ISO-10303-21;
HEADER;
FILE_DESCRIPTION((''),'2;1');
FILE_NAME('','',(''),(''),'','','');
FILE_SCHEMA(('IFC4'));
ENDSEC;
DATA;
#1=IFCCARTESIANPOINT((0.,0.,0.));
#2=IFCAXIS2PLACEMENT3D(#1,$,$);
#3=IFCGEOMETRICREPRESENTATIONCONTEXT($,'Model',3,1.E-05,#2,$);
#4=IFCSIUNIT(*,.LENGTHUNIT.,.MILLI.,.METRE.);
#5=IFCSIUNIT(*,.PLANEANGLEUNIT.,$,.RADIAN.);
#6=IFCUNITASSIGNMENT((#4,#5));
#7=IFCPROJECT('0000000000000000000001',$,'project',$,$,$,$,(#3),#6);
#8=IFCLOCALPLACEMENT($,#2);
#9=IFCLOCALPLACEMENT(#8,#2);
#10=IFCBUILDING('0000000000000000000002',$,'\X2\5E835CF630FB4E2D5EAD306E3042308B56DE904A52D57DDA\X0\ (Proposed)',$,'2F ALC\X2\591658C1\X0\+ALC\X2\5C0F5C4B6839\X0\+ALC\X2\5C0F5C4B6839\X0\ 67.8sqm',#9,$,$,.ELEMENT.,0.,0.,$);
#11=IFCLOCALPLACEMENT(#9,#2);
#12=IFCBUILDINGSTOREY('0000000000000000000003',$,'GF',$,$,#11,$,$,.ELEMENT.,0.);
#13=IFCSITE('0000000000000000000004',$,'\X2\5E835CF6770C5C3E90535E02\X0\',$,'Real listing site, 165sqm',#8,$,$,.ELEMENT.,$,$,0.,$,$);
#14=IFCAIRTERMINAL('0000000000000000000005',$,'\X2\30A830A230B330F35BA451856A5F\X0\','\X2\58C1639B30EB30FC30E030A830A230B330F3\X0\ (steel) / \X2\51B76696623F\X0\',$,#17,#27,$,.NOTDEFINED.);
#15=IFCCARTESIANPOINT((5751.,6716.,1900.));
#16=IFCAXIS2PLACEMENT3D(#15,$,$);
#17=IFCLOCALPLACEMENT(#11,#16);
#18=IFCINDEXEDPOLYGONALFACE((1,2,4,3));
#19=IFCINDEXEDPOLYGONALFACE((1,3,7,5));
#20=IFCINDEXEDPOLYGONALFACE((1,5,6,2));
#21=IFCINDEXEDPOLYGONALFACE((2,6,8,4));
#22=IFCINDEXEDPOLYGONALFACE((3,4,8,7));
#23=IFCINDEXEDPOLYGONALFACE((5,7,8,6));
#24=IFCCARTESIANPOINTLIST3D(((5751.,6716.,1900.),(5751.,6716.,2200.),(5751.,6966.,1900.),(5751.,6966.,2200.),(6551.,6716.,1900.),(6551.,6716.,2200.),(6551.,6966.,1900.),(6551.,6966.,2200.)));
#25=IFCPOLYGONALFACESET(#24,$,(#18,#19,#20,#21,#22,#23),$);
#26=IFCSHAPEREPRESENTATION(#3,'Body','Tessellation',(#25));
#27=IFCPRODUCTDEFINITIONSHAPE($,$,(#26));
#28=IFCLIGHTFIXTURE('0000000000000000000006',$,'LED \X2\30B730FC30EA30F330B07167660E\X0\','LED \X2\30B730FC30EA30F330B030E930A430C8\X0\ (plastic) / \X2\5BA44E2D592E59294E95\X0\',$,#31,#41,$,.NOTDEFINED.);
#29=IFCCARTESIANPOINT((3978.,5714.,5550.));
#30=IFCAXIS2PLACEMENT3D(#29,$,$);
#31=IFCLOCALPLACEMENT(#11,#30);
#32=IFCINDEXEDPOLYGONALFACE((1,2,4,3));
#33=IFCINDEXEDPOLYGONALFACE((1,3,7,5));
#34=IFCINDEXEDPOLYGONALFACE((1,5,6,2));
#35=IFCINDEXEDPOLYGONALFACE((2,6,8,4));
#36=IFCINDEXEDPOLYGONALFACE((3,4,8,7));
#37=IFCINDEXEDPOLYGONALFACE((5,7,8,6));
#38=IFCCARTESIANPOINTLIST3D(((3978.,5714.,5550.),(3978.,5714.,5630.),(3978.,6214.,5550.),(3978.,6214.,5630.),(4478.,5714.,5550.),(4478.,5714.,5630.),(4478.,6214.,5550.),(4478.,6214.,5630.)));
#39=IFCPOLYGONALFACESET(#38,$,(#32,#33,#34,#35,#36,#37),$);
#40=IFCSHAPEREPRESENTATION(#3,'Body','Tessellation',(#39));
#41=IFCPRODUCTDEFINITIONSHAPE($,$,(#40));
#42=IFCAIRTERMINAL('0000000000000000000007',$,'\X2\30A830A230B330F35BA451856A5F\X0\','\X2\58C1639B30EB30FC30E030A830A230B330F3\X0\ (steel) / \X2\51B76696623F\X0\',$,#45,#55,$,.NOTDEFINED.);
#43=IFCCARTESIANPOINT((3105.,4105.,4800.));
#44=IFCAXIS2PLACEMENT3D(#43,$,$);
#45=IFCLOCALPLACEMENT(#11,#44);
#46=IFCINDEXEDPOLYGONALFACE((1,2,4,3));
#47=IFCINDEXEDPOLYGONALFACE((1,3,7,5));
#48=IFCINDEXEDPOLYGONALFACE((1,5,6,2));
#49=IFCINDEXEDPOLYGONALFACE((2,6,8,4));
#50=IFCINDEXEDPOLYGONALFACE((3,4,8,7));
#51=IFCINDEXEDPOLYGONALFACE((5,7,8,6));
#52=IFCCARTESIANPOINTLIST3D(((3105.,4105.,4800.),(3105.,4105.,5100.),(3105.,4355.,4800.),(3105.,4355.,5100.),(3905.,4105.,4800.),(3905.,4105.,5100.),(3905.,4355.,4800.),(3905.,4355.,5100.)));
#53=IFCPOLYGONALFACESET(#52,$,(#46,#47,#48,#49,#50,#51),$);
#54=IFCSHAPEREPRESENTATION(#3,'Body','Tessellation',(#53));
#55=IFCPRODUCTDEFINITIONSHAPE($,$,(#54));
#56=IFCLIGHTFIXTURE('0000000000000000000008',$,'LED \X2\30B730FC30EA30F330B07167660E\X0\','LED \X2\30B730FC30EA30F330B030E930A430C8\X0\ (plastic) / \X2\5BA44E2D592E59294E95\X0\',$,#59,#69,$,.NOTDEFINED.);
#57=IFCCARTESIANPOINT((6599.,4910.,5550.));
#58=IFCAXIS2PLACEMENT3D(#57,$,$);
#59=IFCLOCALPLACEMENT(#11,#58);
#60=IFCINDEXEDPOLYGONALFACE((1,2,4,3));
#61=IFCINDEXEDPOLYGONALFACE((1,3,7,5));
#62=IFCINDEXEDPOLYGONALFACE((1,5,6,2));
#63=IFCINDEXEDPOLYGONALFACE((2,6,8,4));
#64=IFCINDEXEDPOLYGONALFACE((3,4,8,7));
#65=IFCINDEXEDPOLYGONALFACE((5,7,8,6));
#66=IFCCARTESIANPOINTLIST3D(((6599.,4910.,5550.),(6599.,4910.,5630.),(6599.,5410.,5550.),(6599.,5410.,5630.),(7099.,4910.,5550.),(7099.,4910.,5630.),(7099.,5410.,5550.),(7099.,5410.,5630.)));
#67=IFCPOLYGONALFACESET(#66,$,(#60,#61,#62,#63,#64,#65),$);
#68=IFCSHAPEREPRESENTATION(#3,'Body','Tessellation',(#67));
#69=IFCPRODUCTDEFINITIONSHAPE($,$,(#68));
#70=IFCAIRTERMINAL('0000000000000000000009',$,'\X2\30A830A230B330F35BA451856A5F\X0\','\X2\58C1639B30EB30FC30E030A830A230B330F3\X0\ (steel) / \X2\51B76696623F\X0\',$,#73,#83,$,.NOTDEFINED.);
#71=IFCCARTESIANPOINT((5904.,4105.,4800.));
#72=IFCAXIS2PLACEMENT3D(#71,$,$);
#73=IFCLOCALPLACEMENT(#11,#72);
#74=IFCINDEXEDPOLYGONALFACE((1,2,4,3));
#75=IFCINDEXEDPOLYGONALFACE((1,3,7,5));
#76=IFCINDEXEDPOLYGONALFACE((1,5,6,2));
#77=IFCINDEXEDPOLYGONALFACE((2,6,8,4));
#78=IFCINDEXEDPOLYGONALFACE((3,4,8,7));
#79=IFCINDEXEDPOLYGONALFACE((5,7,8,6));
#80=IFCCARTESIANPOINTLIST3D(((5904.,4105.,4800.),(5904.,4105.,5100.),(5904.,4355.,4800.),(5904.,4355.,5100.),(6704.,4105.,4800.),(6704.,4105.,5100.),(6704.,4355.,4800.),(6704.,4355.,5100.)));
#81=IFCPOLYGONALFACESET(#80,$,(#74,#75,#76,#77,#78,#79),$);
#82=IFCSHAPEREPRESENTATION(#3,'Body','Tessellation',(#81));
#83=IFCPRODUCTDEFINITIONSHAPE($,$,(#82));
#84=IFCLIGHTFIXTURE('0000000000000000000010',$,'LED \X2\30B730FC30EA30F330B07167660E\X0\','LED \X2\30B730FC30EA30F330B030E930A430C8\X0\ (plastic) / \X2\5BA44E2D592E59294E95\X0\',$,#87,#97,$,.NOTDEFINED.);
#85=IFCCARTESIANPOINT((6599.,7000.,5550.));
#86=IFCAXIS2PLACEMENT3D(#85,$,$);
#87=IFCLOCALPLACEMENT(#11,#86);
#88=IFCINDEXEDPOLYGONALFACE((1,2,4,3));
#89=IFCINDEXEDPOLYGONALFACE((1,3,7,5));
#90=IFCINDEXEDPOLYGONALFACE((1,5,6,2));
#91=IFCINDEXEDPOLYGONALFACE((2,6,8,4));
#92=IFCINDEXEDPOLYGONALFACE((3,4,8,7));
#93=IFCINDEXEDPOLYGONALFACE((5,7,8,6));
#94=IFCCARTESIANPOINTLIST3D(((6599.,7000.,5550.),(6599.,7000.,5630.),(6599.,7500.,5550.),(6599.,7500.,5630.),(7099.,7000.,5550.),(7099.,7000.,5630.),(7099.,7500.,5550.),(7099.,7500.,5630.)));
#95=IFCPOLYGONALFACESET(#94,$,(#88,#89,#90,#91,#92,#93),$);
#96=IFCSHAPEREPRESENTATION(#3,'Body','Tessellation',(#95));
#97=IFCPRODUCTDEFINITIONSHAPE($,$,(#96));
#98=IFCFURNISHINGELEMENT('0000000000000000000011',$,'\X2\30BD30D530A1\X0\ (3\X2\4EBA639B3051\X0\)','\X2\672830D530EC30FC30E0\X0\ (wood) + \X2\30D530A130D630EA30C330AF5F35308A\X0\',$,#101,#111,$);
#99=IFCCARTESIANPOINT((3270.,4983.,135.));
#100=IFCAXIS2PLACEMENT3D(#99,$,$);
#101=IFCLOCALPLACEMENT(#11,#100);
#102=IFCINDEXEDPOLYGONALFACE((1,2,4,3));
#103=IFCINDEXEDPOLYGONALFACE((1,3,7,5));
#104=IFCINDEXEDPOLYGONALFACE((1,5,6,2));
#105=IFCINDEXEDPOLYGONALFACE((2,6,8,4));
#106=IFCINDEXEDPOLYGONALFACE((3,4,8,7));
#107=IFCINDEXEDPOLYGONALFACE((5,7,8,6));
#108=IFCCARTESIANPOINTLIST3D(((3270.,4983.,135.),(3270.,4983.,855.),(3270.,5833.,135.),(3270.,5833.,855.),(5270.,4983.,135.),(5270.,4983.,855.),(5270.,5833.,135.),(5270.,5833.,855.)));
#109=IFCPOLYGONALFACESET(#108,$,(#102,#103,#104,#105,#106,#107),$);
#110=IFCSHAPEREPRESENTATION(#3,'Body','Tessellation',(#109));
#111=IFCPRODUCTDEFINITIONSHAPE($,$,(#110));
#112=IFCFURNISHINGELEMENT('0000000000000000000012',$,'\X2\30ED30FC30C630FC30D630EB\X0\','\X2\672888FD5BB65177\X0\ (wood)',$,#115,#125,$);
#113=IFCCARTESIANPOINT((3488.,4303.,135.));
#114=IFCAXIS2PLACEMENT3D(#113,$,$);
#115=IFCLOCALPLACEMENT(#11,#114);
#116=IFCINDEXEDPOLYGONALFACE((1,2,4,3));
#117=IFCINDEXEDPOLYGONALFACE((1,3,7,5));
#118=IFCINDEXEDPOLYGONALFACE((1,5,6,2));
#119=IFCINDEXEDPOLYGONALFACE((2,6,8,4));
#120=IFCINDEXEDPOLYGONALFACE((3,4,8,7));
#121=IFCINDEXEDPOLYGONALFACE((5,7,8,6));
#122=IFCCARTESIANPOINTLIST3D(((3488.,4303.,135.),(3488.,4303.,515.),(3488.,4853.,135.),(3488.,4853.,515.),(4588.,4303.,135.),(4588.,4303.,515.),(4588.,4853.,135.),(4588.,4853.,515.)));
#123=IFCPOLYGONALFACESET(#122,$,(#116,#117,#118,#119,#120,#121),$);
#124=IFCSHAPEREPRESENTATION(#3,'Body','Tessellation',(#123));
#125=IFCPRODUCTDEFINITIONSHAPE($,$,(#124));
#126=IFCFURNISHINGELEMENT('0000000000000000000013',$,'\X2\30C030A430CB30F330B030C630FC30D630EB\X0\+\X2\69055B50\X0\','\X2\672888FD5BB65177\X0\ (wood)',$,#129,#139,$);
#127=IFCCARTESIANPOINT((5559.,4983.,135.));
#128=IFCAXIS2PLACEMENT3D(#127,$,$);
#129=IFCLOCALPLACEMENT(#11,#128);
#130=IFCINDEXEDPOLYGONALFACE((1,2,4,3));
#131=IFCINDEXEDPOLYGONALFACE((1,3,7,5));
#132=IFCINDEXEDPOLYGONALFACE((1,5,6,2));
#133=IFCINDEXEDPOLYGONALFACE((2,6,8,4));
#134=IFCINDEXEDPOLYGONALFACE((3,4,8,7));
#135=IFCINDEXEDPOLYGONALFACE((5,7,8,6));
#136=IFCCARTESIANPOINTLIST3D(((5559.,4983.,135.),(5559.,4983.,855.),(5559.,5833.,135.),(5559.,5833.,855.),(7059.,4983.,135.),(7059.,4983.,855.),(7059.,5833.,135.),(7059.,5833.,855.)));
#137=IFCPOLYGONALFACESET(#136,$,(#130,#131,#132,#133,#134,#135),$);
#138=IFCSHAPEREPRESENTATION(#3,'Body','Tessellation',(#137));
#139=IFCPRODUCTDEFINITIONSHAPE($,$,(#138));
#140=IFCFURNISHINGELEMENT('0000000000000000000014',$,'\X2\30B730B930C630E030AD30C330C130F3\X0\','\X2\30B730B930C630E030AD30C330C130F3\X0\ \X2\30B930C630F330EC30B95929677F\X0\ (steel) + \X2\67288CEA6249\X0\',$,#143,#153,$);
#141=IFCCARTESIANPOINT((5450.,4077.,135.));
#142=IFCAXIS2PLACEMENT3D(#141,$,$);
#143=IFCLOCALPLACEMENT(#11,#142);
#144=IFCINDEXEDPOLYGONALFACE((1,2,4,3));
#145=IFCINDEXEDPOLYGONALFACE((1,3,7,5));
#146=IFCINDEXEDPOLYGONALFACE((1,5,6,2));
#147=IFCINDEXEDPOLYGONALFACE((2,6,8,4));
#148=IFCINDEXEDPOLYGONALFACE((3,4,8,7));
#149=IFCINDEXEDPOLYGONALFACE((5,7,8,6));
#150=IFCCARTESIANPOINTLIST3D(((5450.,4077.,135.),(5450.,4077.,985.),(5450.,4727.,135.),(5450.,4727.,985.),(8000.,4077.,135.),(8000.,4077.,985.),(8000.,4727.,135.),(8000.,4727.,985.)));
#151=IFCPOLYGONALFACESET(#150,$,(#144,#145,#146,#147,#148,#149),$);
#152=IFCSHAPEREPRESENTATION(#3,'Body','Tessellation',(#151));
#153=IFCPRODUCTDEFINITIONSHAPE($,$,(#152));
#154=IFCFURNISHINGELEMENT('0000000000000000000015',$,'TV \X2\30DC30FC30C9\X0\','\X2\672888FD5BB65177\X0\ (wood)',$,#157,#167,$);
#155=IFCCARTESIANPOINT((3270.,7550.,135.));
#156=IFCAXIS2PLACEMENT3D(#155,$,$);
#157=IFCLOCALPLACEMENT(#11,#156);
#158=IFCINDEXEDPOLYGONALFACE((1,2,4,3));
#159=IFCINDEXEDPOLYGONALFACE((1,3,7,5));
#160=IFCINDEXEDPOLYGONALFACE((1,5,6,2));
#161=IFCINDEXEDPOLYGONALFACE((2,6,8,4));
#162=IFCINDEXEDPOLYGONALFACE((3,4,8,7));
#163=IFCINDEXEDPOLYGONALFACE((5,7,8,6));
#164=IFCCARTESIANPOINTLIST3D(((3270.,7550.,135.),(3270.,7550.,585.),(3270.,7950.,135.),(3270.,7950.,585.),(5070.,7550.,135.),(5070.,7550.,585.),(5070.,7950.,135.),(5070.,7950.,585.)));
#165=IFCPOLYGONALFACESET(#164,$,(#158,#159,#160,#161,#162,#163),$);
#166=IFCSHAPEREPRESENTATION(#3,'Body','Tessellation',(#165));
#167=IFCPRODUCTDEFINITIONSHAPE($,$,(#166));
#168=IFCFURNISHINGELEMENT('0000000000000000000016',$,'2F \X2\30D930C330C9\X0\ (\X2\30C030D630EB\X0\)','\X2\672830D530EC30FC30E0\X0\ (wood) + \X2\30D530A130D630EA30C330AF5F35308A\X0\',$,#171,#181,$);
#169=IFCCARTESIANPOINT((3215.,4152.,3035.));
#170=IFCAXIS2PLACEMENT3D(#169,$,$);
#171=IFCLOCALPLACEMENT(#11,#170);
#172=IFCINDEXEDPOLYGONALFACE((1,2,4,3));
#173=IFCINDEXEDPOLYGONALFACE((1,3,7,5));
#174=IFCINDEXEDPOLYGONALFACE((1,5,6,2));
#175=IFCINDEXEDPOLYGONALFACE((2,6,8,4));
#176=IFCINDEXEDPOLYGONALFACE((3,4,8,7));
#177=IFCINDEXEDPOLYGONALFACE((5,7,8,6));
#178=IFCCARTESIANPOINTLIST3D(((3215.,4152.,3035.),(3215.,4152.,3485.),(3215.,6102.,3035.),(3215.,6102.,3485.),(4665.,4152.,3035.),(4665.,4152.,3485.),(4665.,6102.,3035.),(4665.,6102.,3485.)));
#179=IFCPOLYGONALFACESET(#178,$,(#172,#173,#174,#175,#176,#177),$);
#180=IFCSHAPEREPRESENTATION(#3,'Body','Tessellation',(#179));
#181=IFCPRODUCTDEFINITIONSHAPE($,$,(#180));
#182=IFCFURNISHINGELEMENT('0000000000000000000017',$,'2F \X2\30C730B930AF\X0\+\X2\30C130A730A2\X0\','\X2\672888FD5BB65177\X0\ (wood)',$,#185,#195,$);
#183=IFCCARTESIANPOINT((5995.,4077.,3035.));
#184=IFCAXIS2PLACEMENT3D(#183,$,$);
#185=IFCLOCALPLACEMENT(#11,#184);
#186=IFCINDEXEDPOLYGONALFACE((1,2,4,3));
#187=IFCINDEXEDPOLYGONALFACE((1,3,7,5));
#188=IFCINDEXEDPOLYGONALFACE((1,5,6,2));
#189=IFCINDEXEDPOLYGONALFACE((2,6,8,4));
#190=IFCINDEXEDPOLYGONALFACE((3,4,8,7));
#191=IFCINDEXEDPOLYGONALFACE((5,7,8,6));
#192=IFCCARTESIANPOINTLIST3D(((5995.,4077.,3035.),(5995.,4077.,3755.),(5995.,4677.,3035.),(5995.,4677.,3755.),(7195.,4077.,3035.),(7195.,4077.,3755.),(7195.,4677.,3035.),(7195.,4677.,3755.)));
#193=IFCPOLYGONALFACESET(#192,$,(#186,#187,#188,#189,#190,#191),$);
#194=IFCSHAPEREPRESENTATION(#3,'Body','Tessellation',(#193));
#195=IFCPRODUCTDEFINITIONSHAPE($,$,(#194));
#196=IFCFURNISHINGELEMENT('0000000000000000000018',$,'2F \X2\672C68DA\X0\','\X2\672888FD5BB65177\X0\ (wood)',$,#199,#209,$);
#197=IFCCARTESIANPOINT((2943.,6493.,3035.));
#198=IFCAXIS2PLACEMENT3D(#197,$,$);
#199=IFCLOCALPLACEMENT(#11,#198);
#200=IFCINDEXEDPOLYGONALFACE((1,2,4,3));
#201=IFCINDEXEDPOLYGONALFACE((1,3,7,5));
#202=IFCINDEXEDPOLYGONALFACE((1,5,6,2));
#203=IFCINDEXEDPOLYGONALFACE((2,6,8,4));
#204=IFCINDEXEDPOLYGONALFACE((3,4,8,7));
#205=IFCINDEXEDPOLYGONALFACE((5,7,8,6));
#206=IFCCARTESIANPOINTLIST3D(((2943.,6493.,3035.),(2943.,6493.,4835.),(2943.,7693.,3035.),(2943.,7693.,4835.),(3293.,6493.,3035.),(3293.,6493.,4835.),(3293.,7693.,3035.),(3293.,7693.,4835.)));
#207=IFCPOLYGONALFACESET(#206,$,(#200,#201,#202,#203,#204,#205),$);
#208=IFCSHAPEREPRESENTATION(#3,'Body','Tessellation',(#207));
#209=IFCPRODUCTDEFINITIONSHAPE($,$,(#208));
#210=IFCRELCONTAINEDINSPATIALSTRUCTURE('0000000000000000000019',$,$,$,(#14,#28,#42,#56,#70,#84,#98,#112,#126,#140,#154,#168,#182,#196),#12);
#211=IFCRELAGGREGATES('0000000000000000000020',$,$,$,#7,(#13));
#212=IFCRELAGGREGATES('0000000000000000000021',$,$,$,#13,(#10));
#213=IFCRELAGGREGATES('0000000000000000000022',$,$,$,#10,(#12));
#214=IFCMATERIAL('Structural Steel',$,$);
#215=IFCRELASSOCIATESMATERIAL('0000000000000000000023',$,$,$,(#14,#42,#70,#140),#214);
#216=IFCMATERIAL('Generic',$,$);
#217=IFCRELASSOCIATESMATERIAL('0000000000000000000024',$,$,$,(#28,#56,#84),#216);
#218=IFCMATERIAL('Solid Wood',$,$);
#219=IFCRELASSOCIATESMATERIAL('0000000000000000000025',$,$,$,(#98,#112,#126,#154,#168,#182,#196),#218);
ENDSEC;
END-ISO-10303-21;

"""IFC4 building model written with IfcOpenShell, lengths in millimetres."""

from ifc_helpers import new_model, si_unit, frame, frame_2d, origin, place, context, project, spatial, rectangle, extrude, material, element, save


model = new_model("IFC4")

# Units and contexts
model_context = context("Model", 3, precision=1e-05, world=origin())
ifc_project = project(units=[si_unit("LENGTHUNIT", "METRE", prefix="MILLI"), si_unit("PLANEANGLEUNIT", "RADIAN")], contexts=[model_context])

# Site, building, storey
site_placement = place(None, origin())
site = spatial("IfcSite", under=ifc_project, at=site_placement, Name="広島県尾道市", ObjectType="Real listing site, 165sqm", CompositionType="ELEMENT", RefElevation=0.0)
building_placement = place(site_placement, origin())
building = spatial("IfcBuilding", under=site, at=building_placement, Name="広島・中庭のある回遊動線 (Proposed)", ObjectType="2F ALC外壁+ALC小屋根+ALC小屋根 67.8sqm", CompositionType="ELEMENT", ElevationOfRefHeight=0.0, ElevationOfTerrain=0.0)
storey_placement = place(building_placement, origin())
storey = spatial("IfcBuildingStorey", under=building, at=storey_placement, Name="GF", CompositionType="ELEMENT", Elevation=0.0)

# Shared definitions
ifc_material_1 = material(Name="Solid Wood")

# Shared definitions
ifc_material_2 = material(Name="Structural Steel")

# Shared definitions
ifc_material_3 = material(Name="Generic")

# Air terminal
air_terminal_1_placement = place(storey_placement, frame((5751.0, 6716.0, 1900.0)))
element("IfcAirTerminal", 1, at=air_terminal_1_placement, inside=storey, material=ifc_material_2, Name="エアコン室内機", Description="壁掛ルームエアコン (steel) / 冷暖房", PredefinedType="NOTDEFINED", context=model_context, shape_type="SweptSolid", body=[
    extrude(rectangle(XDim=800.0, YDim=250.0, at=frame_2d((400.0, 125.0))), frame((5751.0, 6716.0, 1900.0)), (0.0, 0.0, 1.0), 300.0),
])

# Light fixture
light_fixture_1_placement = place(storey_placement, frame((3978.0, 5714.0, 5550.0)))
element("IfcLightFixture", 2, at=light_fixture_1_placement, inside=storey, material=ifc_material_3, Name="LED シーリング照明", Description="LED シーリングライト (plastic) / 室中央天井", PredefinedType="NOTDEFINED", context=model_context, shape_type="SweptSolid", body=[
    extrude(rectangle(XDim=500.0, YDim=500.0, at=frame_2d((250.0, 250.0))), frame((3978.0, 5714.0, 5550.0)), (0.0, 0.0, 1.0), 80.0),
])

# Air terminal
air_terminal_2_placement = place(storey_placement, frame((3105.0, 4105.0, 4800.0)))
element("IfcAirTerminal", 3, at=air_terminal_2_placement, inside=storey, material=ifc_material_2, Name="エアコン室内機", Description="壁掛ルームエアコン (steel) / 冷暖房", PredefinedType="NOTDEFINED", context=model_context, shape_type="SweptSolid", body=[
    extrude(rectangle(XDim=800.0, YDim=250.0, at=frame_2d((400.0, 125.0))), frame((3105.0, 4105.0, 4800.0)), (0.0, 0.0, 1.0), 300.0),
])

# Light fixture
light_fixture_2_placement = place(storey_placement, frame((6599.0, 4910.0, 5550.0)))
element("IfcLightFixture", 4, at=light_fixture_2_placement, inside=storey, material=ifc_material_3, Name="LED シーリング照明", Description="LED シーリングライト (plastic) / 室中央天井", PredefinedType="NOTDEFINED", context=model_context, shape_type="SweptSolid", body=[
    extrude(rectangle(XDim=500.0, YDim=500.0, at=frame_2d((250.0, 250.0))), frame((6599.0, 4910.0, 5550.0)), (0.0, 0.0, 1.0), 80.0),
])

# Air terminal
air_terminal_3_placement = place(storey_placement, frame((5904.0, 4105.0, 4800.0)))
element("IfcAirTerminal", 5, at=air_terminal_3_placement, inside=storey, material=ifc_material_2, Name="エアコン室内機", Description="壁掛ルームエアコン (steel) / 冷暖房", PredefinedType="NOTDEFINED", context=model_context, shape_type="SweptSolid", body=[
    extrude(rectangle(XDim=800.0, YDim=250.0, at=frame_2d((400.0, 125.0))), frame((5904.0, 4105.0, 4800.0)), (0.0, 0.0, 1.0), 300.0),
])

# Light fixture
light_fixture_3_placement = place(storey_placement, frame((6599.0, 7000.0, 5550.0)))
element("IfcLightFixture", 6, at=light_fixture_3_placement, inside=storey, material=ifc_material_3, Name="LED シーリング照明", Description="LED シーリングライト (plastic) / 室中央天井", PredefinedType="NOTDEFINED", context=model_context, shape_type="SweptSolid", body=[
    extrude(rectangle(XDim=500.0, YDim=500.0, at=frame_2d((250.0, 250.0))), frame((6599.0, 7000.0, 5550.0)), (0.0, 0.0, 1.0), 80.0),
])

# Furnishing elements
furnishing_1_placement = place(storey_placement, frame((3270.0, 4983.0, 135.0)))
element("IfcFurnishingElement", 7, at=furnishing_1_placement, inside=storey, material=ifc_material_1, Name="ソファ (3人掛け)", Description="木フレーム (wood) + ファブリック張り", context=model_context, shape_type="SweptSolid", body=[
    extrude(rectangle(XDim=2000.0, YDim=850.0, at=frame_2d((1000.0, 425.0))), frame((3270.0, 4983.0, 135.0)), (0.0, 0.0, 1.0), 720.0),
])
furnishing_2_placement = place(storey_placement, frame((3488.0, 4303.0, 135.0)))
element("IfcFurnishingElement", 8, at=furnishing_2_placement, inside=storey, material=ifc_material_1, Name="ローテーブル", Description="木製家具 (wood)", context=model_context, shape_type="SweptSolid", body=[
    extrude(rectangle(XDim=1100.0, YDim=550.0, at=frame_2d((550.0, 275.0))), frame((3488.0, 4303.0, 135.0)), (0.0, 0.0, 1.0), 380.0),
])
furnishing_3_placement = place(storey_placement, frame((5559.0, 4983.0, 135.0)))
element("IfcFurnishingElement", 9, at=furnishing_3_placement, inside=storey, material=ifc_material_1, Name="ダイニングテーブル+椅子", Description="木製家具 (wood)", context=model_context, shape_type="SweptSolid", body=[
    extrude(rectangle(XDim=1500.0, YDim=850.0, at=frame_2d((750.0, 425.0))), frame((5559.0, 4983.0, 135.0)), (0.0, 0.0, 1.0), 720.0),
])
furnishing_4_placement = place(storey_placement, frame((5450.0, 4077.0, 135.0)))
element("IfcFurnishingElement", 10, at=furnishing_4_placement, inside=storey, material=ifc_material_2, Name="システムキッチン", Description="システムキッチン ステンレス天板 (steel) + 木質扉", context=model_context, shape_type="SweptSolid", body=[
    extrude(rectangle(XDim=2550.0, YDim=650.0, at=frame_2d((1275.0, 325.0))), frame((5450.0, 4077.0, 135.0)), (0.0, 0.0, 1.0), 850.0),
])
furnishing_5_placement = place(storey_placement, frame((3270.0, 7550.0, 135.0)))
element("IfcFurnishingElement", 11, at=furnishing_5_placement, inside=storey, material=ifc_material_1, Name="TV ボード", Description="木製家具 (wood)", context=model_context, shape_type="SweptSolid", body=[
    extrude(rectangle(XDim=1800.0, YDim=400.0, at=frame_2d((900.0, 200.0))), frame((3270.0, 7550.0, 135.0)), (0.0, 0.0, 1.0), 450.0),
])
furnishing_6_placement = place(storey_placement, frame((3215.0, 4152.0, 3035.0)))
element("IfcFurnishingElement", 12, at=furnishing_6_placement, inside=storey, material=ifc_material_1, Name="2F ベッド (ダブル)", Description="木フレーム (wood) + ファブリック張り", context=model_context, shape_type="SweptSolid", body=[
    extrude(rectangle(XDim=1450.0, YDim=1950.0, at=frame_2d((725.0, 975.0))), frame((3215.0, 4152.0, 3035.0)), (0.0, 0.0, 1.0), 450.0),
])
furnishing_7_placement = place(storey_placement, frame((5995.0, 4077.0, 3035.0)))
element("IfcFurnishingElement", 13, at=furnishing_7_placement, inside=storey, material=ifc_material_1, Name="2F デスク+チェア", Description="木製家具 (wood)", context=model_context, shape_type="SweptSolid", body=[
    extrude(rectangle(XDim=1200.0, YDim=600.0, at=frame_2d((600.0, 300.0))), frame((5995.0, 4077.0, 3035.0)), (0.0, 0.0, 1.0), 720.0),
])
furnishing_8_placement = place(storey_placement, frame((2943.0, 6493.0, 3035.0)))
element("IfcFurnishingElement", 14, at=furnishing_8_placement, inside=storey, material=ifc_material_1, Name="2F 本棚", Description="木製家具 (wood)", context=model_context, shape_type="SweptSolid", body=[
    extrude(rectangle(XDim=350.0, YDim=1200.0, at=frame_2d((175.0, 600.0))), frame((2943.0, 6493.0, 3035.0)), (0.0, 0.0, 1.0), 1800.0),
])

save(model, "model.ifc")
